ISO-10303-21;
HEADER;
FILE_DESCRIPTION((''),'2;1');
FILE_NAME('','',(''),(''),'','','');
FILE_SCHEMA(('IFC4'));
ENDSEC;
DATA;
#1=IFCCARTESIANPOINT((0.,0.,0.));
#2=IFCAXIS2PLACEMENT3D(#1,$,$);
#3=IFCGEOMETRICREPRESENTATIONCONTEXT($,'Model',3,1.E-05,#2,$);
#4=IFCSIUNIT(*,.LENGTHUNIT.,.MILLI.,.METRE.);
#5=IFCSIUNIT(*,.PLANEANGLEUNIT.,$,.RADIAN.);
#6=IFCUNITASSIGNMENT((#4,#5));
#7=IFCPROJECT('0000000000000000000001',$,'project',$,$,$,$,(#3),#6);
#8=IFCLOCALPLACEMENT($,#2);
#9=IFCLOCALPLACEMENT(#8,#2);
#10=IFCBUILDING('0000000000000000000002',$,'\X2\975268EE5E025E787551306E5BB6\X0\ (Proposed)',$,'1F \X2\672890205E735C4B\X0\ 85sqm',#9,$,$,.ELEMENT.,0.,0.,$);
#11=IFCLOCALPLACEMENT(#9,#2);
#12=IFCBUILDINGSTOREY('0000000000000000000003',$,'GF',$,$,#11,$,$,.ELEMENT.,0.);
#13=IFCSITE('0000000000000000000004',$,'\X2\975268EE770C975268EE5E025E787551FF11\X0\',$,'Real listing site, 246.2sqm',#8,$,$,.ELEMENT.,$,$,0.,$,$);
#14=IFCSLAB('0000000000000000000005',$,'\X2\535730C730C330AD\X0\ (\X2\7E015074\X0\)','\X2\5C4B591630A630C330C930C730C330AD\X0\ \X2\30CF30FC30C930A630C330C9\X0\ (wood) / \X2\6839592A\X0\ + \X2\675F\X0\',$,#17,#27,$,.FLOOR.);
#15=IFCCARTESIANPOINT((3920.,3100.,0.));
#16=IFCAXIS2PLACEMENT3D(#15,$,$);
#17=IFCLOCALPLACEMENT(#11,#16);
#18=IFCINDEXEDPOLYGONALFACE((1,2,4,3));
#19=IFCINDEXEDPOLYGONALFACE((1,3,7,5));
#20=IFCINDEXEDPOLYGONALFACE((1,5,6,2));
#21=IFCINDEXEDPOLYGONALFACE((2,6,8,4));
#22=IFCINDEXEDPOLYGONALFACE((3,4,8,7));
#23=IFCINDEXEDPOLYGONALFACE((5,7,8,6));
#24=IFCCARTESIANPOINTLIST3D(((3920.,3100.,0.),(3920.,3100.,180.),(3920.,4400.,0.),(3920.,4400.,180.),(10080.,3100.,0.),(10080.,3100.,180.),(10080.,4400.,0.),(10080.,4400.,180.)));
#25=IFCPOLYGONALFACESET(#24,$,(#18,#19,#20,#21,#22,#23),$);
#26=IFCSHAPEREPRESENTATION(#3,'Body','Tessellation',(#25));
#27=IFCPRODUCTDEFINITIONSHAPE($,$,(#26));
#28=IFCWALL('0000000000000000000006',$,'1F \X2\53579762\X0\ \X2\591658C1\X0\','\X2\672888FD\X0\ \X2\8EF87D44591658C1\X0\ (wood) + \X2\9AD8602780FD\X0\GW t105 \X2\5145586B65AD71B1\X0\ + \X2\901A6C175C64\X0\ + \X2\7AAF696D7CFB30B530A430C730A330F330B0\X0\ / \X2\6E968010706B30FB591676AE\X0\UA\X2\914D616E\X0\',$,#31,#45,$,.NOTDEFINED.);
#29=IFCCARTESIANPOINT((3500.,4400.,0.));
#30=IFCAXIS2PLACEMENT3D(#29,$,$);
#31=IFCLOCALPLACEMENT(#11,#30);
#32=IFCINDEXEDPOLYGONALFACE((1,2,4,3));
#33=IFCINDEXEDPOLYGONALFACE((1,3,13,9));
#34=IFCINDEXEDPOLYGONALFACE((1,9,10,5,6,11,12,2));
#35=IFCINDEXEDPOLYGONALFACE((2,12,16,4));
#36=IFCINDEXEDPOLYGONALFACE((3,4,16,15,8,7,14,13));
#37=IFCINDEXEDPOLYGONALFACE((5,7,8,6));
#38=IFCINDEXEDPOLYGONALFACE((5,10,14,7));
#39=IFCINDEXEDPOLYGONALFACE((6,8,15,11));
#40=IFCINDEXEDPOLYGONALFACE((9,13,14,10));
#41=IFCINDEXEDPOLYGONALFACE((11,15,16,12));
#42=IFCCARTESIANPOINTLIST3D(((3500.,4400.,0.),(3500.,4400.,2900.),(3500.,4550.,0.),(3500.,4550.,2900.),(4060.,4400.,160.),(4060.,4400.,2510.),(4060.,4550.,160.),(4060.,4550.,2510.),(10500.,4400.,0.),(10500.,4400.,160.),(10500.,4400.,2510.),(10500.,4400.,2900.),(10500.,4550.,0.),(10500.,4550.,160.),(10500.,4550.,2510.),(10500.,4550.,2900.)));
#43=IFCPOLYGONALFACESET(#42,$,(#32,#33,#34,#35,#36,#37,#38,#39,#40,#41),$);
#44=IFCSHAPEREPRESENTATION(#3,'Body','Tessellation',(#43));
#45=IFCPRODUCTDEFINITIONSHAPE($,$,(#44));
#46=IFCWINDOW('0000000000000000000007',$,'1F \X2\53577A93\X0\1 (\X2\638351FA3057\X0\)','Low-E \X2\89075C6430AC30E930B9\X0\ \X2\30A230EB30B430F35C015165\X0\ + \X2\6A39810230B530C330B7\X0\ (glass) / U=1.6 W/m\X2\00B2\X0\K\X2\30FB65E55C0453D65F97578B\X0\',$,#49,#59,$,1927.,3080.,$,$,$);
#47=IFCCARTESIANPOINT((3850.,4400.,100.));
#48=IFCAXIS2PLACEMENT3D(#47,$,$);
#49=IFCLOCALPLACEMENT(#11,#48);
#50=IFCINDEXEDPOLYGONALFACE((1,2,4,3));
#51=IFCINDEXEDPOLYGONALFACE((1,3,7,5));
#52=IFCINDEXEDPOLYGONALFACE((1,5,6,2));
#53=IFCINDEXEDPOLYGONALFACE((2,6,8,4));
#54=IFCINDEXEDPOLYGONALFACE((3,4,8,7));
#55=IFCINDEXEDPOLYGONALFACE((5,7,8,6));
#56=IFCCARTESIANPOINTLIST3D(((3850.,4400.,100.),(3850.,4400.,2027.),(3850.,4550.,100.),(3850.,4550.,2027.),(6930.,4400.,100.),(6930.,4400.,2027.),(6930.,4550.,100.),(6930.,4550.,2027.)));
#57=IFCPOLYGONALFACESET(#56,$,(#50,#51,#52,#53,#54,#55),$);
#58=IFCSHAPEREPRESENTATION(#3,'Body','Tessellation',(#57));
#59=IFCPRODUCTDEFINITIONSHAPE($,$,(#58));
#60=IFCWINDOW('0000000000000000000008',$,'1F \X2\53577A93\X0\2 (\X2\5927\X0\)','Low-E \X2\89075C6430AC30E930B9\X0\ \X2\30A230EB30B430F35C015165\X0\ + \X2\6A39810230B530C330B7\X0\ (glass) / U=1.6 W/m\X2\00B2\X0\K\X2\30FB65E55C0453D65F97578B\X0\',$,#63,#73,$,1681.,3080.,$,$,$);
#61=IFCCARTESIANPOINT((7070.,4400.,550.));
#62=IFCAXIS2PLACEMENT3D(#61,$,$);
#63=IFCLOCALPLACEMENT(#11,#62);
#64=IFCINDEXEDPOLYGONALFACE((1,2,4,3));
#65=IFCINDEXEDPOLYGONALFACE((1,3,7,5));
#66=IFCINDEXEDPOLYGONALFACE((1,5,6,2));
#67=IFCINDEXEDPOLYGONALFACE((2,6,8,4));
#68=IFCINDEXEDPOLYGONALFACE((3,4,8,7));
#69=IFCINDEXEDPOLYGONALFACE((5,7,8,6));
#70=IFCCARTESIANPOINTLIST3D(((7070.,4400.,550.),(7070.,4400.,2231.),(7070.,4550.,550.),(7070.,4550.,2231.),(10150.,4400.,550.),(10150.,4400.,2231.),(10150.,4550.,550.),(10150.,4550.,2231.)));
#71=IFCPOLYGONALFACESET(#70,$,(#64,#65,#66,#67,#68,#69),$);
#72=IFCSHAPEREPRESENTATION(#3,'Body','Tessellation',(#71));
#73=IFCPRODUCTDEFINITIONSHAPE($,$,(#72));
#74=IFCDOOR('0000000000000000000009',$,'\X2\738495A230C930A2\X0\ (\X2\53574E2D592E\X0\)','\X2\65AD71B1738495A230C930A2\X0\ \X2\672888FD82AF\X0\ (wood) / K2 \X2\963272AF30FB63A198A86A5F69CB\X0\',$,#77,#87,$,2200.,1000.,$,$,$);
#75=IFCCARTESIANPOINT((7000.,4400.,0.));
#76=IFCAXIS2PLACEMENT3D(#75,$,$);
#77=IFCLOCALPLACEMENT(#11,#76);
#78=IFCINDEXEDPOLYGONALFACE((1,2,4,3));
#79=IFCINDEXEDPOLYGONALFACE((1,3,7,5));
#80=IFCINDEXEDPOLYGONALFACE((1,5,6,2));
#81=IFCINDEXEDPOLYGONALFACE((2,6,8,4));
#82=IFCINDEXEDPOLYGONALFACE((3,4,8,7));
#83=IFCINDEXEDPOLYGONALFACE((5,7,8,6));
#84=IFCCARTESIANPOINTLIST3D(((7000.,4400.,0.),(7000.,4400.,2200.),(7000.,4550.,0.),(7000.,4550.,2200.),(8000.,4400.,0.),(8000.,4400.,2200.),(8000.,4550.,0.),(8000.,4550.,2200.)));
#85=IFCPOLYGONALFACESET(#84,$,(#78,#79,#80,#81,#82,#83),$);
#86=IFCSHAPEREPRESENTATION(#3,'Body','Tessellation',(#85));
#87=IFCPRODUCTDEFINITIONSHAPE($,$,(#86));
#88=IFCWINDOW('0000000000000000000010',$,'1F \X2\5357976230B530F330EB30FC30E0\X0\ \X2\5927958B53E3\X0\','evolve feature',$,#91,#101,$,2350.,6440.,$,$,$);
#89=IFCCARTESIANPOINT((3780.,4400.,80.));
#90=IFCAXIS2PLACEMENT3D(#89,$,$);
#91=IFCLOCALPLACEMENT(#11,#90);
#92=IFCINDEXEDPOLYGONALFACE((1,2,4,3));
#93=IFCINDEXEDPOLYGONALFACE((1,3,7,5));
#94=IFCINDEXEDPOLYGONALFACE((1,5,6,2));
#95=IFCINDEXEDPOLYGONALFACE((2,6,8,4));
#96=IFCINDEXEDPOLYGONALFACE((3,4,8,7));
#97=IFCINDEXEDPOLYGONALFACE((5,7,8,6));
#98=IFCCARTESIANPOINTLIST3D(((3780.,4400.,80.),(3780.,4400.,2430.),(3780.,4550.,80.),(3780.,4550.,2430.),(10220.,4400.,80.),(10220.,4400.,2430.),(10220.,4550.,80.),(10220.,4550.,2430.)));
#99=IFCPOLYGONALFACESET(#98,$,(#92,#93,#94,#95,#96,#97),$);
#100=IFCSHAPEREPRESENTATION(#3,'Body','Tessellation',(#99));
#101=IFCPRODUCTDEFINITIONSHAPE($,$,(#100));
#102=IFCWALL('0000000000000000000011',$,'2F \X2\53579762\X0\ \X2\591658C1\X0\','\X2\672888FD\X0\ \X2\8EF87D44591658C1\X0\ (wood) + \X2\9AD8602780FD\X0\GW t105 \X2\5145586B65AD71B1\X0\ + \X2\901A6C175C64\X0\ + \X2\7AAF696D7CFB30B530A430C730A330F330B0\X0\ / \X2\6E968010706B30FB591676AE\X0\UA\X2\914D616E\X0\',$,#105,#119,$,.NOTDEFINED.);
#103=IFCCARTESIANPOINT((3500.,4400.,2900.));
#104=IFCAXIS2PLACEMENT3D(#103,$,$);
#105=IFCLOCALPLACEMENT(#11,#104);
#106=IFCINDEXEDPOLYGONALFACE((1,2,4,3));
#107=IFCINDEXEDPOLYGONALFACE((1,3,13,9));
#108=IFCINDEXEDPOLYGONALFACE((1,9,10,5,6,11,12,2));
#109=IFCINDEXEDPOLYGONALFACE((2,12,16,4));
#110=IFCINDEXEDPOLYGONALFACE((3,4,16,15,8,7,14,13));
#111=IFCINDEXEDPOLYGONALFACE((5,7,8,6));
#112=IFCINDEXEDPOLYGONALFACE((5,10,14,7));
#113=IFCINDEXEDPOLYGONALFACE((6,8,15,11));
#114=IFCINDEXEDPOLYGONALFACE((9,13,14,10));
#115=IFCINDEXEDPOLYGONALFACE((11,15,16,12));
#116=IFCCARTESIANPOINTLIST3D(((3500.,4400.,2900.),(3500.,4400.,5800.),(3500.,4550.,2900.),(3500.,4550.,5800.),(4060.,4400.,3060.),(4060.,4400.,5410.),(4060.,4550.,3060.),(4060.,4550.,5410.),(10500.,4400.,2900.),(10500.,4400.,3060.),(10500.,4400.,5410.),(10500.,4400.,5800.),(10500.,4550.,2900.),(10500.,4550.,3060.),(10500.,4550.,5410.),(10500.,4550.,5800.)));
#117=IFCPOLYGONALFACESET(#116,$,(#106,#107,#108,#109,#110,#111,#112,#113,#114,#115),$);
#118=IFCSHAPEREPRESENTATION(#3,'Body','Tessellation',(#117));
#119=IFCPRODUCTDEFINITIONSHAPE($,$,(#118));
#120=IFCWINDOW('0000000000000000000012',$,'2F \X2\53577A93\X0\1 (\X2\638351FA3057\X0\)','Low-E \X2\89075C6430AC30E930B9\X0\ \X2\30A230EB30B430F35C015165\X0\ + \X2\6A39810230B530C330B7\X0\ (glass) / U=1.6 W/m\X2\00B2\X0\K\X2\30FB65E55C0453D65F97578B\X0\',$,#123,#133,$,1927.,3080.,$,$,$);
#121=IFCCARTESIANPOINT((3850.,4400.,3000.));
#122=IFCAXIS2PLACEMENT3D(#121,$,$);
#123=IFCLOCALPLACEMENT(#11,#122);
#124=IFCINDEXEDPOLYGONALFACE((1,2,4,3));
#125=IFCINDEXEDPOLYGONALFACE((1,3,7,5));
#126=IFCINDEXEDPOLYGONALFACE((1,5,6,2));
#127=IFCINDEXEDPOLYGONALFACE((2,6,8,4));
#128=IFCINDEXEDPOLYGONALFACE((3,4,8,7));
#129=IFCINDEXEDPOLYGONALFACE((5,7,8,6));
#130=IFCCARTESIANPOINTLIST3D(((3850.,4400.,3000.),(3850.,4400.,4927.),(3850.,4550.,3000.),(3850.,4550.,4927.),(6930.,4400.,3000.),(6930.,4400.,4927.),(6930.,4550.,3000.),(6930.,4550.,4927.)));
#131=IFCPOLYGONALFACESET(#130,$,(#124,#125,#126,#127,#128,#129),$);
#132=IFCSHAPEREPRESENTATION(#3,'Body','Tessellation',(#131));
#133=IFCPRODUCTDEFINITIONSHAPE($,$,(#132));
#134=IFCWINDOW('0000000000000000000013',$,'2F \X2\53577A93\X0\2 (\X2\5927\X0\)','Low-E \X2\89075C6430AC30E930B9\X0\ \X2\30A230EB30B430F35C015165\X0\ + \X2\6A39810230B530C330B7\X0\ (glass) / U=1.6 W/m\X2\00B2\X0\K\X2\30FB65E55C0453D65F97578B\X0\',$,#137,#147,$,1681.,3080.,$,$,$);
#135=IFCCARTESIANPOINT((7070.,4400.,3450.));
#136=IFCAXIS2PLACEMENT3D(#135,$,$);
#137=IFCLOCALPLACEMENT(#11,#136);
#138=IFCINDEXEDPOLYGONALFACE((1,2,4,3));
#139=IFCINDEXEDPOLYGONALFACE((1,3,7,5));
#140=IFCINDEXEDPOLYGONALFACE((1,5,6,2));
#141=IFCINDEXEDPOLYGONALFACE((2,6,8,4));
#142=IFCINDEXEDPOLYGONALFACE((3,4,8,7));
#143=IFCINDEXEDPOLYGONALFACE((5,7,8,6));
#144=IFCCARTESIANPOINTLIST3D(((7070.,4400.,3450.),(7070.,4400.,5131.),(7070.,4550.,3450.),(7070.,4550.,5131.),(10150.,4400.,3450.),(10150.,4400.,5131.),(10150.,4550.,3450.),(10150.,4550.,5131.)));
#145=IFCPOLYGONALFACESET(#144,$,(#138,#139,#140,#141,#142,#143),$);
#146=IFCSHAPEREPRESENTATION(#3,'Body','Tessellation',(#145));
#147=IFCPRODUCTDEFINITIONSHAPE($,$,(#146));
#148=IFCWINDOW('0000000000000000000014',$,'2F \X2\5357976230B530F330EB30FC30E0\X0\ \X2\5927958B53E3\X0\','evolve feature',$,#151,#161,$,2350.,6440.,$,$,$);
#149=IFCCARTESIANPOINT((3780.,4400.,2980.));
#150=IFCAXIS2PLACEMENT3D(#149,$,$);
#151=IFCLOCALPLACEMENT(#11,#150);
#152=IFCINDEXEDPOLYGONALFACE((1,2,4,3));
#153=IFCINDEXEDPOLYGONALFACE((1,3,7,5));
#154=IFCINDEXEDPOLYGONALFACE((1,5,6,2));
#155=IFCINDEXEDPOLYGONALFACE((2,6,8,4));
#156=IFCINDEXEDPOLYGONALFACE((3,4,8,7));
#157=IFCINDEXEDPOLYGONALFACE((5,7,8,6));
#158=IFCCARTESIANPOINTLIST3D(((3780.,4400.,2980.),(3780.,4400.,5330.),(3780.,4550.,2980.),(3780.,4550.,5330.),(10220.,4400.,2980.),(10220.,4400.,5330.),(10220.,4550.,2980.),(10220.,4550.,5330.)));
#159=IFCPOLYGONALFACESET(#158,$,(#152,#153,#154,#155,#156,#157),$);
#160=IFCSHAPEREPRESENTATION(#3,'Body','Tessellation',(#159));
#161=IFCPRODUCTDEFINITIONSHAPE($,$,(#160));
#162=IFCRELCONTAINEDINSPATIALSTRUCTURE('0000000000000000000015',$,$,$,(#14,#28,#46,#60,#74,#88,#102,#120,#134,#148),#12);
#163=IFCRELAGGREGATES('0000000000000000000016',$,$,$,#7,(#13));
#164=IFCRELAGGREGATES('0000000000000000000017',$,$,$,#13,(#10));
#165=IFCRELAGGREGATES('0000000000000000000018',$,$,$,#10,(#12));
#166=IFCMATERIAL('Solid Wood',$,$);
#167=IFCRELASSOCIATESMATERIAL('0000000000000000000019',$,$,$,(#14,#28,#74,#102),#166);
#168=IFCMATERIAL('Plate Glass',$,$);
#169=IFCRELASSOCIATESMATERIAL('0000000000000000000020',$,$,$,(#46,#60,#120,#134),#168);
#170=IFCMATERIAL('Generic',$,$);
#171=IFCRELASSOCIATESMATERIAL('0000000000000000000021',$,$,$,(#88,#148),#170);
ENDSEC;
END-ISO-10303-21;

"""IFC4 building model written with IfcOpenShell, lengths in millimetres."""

from ifc_helpers import new_model, si_unit, frame, frame_2d, origin, place, context, project, spatial, rectangle, extrude, material, element, fill, save


model = new_model("IFC4")

# Units and contexts
model_context = context("Model", 3, precision=1e-05, world=origin())
ifc_project = project(units=[si_unit("LENGTHUNIT", "METRE", prefix="MILLI"), si_unit("PLANEANGLEUNIT", "RADIAN")], contexts=[model_context])

# Site, building, storey
site_placement = place(None, origin())
site = spatial("IfcSite", under=ifc_project, at=site_placement, Name="青森県青森市幸畑１", ObjectType="Real listing site, 246.2sqm", CompositionType="ELEMENT", RefElevation=0.0)
building_placement = place(site_placement, origin())
building = spatial("IfcBuilding", under=site, at=building_placement, Name="青森市幸畑の家 (Proposed)", ObjectType="1F 木造平屋 85sqm", CompositionType="ELEMENT", ElevationOfRefHeight=0.0, ElevationOfTerrain=0.0)
storey_placement = place(building_placement, origin())
storey = spatial("IfcBuildingStorey", under=building, at=storey_placement, Name="GF", CompositionType="ELEMENT", Elevation=0.0)

# Slab
ifc_material_1 = material(Name="Solid Wood")
slab_1_placement = place(storey_placement, frame((3920.0, 3100.0, 0.0)))
element("IfcSlab", 1, at=slab_1_placement, inside=storey, material=ifc_material_1, Name="南デッキ (縁側)", Description="屋外ウッドデッキ ハードウッド (wood) / 根太 + 束", PredefinedType="FLOOR", context=model_context, shape_type="SweptSolid", body=[
    extrude(rectangle(XDim=6160.0, YDim=1300.0, at=frame_2d((3080.0, 650.0))), frame((3920.0, 3100.0, 0.0)), (0.0, 0.0, 1.0), 180.0),
])
ifc_material_2 = material(Name="Generic")

# Wall, openings, windows, door
wall_1_placement = place(storey_placement, frame((3500.0, 4400.0, 0.0)))
wall_1 = element("IfcWall", 2, at=wall_1_placement, inside=storey, material=ifc_material_1, Name="1F 南面 外壁", Description="木製 軸組外壁 (wood) + 高性能GW t105 充填断熱 + 通気層 + 窯業系サイディング / 準耐火・外皮UA配慮", PredefinedType="NOTDEFINED", context=model_context, shape_type="SweptSolid", body=[
    extrude(rectangle(XDim=7000.0, YDim=150.0, at=frame_2d((3500.0, 75.0))), frame((3500.0, 4400.0, 0.0)), (0.0, 0.0, 1.0), 2900.0),
])
opening_1_placement = place(storey_placement, frame((3850.0, 4400.0, 100.0)))
opening_1 = element("IfcOpeningElement", 3, at=opening_1_placement, cuts=wall_1, PredefinedType="NOTDEFINED", context=model_context, shape_type="SweptSolid", body=[
    extrude(rectangle(XDim=3080.0, YDim=150.0, at=frame_2d((1540.0, 75.0))), frame((3850.0, 4400.0, 100.0)), (0.0, 0.0, 1.0), 1927.0),
])
opening_2_placement = place(storey_placement, frame((7070.0, 4400.0, 550.0)))
opening_2 = element("IfcOpeningElement", 4, at=opening_2_placement, cuts=wall_1, PredefinedType="NOTDEFINED", context=model_context, shape_type="SweptSolid", body=[
    extrude(rectangle(XDim=3080.0, YDim=150.0, at=frame_2d((1540.0, 75.0))), frame((7070.0, 4400.0, 550.0)), (0.0, 0.0, 1.0), 1681.0),
])
opening_3_placement = place(storey_placement, frame((7000.0, 4400.0, 0.0)))
opening_3 = element("IfcOpeningElement", 5, at=opening_3_placement, cuts=wall_1, PredefinedType="NOTDEFINED", context=model_context, shape_type="SweptSolid", body=[
    extrude(rectangle(XDim=1000.0, YDim=150.0, at=frame_2d((500.0, 75.0))), frame((7000.0, 4400.0, 0.0)), (0.0, 0.0, 1.0), 2200.0),
])
opening_4_placement = place(storey_placement, frame((3780.0, 4400.0, 80.0)))
opening_4 = element("IfcOpeningElement", 6, at=opening_4_placement, cuts=wall_1, PredefinedType="NOTDEFINED", context=model_context, shape_type="SweptSolid", body=[
    extrude(rectangle(XDim=6440.0, YDim=150.0, at=frame_2d((3220.0, 75.0))), frame((3780.0, 4400.0, 80.0)), (0.0, 0.0, 1.0), 2350.0),
])
ifc_material_3 = material(Name="Plate Glass")
window_1_placement = place(storey_placement, frame((3850.0, 4400.0, 100.0)))
window_1 = element("IfcWindow", 7, at=window_1_placement, inside=storey, material=ifc_material_3, Name="1F 南窓1 (掃出し)", Description="Low-E 複層ガラス アルゴン封入 + 樹脂サッシ (glass) / U=1.6 W/m²K・日射取得型", OverallHeight=1927.0, OverallWidth=3080.0, context=model_context, shape_type="SweptSolid", body=[
    extrude(rectangle(XDim=3080.0, YDim=150.0, at=frame_2d((1540.0, 75.0))), frame((3850.0, 4400.0, 100.0)), (0.0, 0.0, 1.0), 1927.0),
])
fill(opening_1, window_1)
window_2_placement = place(storey_placement, frame((7070.0, 4400.0, 550.0)))
window_2 = element("IfcWindow", 8, at=window_2_placement, inside=storey, material=ifc_material_3, Name="1F 南窓2 (大)", Description="Low-E 複層ガラス アルゴン封入 + 樹脂サッシ (glass) / U=1.6 W/m²K・日射取得型", OverallHeight=1681.0, OverallWidth=3080.0, context=model_context, shape_type="SweptSolid", body=[
    extrude(rectangle(XDim=3080.0, YDim=150.0, at=frame_2d((1540.0, 75.0))), frame((7070.0, 4400.0, 550.0)), (0.0, 0.0, 1.0), 1681.0),
])
fill(opening_2, window_2)
door_placement = place(storey_placement, frame((7000.0, 4400.0, 0.0)))
door = element("IfcDoor", 9, at=door_placement, inside=storey, material=ifc_material_1, Name="玄関ドア (南中央)", Description="断熱玄関ドア 木製芯 (wood) / K2 防犯・採風機構", OverallHeight=2200.0, OverallWidth=1000.0, context=model_context, shape_type="SweptSolid", body=[
    extrude(rectangle(XDim=1000.0, YDim=150.0, at=frame_2d((500.0, 75.0))), frame((7000.0, 4400.0, 0.0)), (0.0, 0.0, 1.0), 2200.0),
])
fill(opening_3, door)
window_3_placement = place(storey_placement, frame((3780.0, 4400.0, 80.0)))
window_3 = element("IfcWindow", 10, at=window_3_placement, inside=storey, material=ifc_material_2, Name="1F 南面サンルーム 大開口", Description="evolve feature", OverallHeight=2350.0, OverallWidth=6440.0, context=model_context, shape_type="SweptSolid", body=[
    extrude(rectangle(XDim=6440.0, YDim=150.0, at=frame_2d((3220.0, 75.0))), frame((3780.0, 4400.0, 80.0)), (0.0, 0.0, 1.0), 2350.0),
])
fill(opening_4, window_3)

# Wall, openings, windows
wall_2_placement = place(storey_placement, frame((3500.0, 4400.0, 2900.0)))
wall_2 = element("IfcWall", 11, at=wall_2_placement, inside=storey, material=ifc_material_1, Name="2F 南面 外壁", Description="木製 軸組外壁 (wood) + 高性能GW t105 充填断熱 + 通気層 + 窯業系サイディング / 準耐火・外皮UA配慮", PredefinedType="NOTDEFINED", context=model_context, shape_type="SweptSolid", body=[
    extrude(rectangle(XDim=7000.0, YDim=150.0, at=frame_2d((3500.0, 75.0))), frame((3500.0, 4400.0, 2900.0)), (0.0, 0.0, 1.0), 2900.0),
])
opening_5_placement = place(storey_placement, frame((3850.0, 4400.0, 3000.0)))
opening_5 = element("IfcOpeningElement", 12, at=opening_5_placement, cuts=wall_2, PredefinedType="NOTDEFINED", context=model_context, shape_type="SweptSolid", body=[
    extrude(rectangle(XDim=3080.0, YDim=150.0, at=frame_2d((1540.0, 75.0))), frame((3850.0, 4400.0, 3000.0)), (0.0, 0.0, 1.0), 1927.0),
])
opening_6_placement = place(storey_placement, frame((7070.0, 4400.0, 3450.0)))
opening_6 = element("IfcOpeningElement", 13, at=opening_6_placement, cuts=wall_2, PredefinedType="NOTDEFINED", context=model_context, shape_type="SweptSolid", body=[
    extrude(rectangle(XDim=3080.0, YDim=150.0, at=frame_2d((1540.0, 75.0))), frame((7070.0, 4400.0, 3450.0)), (0.0, 0.0, 1.0), 1681.0),
])
opening_7_placement = place(storey_placement, frame((3780.0, 4400.0, 2980.0)))
opening_7 = element("IfcOpeningElement", 14, at=opening_7_placement, cuts=wall_2, PredefinedType="NOTDEFINED", context=model_context, shape_type="SweptSolid", body=[
    extrude(rectangle(XDim=6440.0, YDim=150.0, at=frame_2d((3220.0, 75.0))), frame((3780.0, 4400.0, 2980.0)), (0.0, 0.0, 1.0), 2350.0),
])
window_4_placement = place(storey_placement, frame((3850.0, 4400.0, 3000.0)))
window_4 = element("IfcWindow", 15, at=window_4_placement, inside=storey, material=ifc_material_3, Name="2F 南窓1 (掃出し)", Description="Low-E 複層ガラス アルゴン封入 + 樹脂サッシ (glass) / U=1.6 W/m²K・日射取得型", OverallHeight=1927.0, OverallWidth=3080.0, context=model_context, shape_type="SweptSolid", body=[
    extrude(rectangle(XDim=3080.0, YDim=150.0, at=frame_2d((1540.0, 75.0))), frame((3850.0, 4400.0, 3000.0)), (0.0, 0.0, 1.0), 1927.0),
])
fill(opening_5, window_4)
window_5_placement = place(storey_placement, frame((7070.0, 4400.0, 3450.0)))
window_5 = element("IfcWindow", 16, at=window_5_placement, inside=storey, material=ifc_material_3, Name="2F 南窓2 (大)", Description="Low-E 複層ガラス アルゴン封入 + 樹脂サッシ (glass) / U=1.6 W/m²K・日射取得型", OverallHeight=1681.0, OverallWidth=3080.0, context=model_context, shape_type="SweptSolid", body=[
    extrude(rectangle(XDim=3080.0, YDim=150.0, at=frame_2d((1540.0, 75.0))), frame((7070.0, 4400.0, 3450.0)), (0.0, 0.0, 1.0), 1681.0),
])
fill(opening_6, window_5)
window_6_placement = place(storey_placement, frame((3780.0, 4400.0, 2980.0)))
window_6 = element("IfcWindow", 17, at=window_6_placement, inside=storey, material=ifc_material_2, Name="2F 南面サンルーム 大開口", Description="evolve feature", OverallHeight=2350.0, OverallWidth=6440.0, context=model_context, shape_type="SweptSolid", body=[
    extrude(rectangle(XDim=6440.0, YDim=150.0, at=frame_2d((3220.0, 75.0))), frame((3780.0, 4400.0, 2980.0)), (0.0, 0.0, 1.0), 2350.0),
])
fill(opening_7, window_6)

save(model, "model.ifc")
